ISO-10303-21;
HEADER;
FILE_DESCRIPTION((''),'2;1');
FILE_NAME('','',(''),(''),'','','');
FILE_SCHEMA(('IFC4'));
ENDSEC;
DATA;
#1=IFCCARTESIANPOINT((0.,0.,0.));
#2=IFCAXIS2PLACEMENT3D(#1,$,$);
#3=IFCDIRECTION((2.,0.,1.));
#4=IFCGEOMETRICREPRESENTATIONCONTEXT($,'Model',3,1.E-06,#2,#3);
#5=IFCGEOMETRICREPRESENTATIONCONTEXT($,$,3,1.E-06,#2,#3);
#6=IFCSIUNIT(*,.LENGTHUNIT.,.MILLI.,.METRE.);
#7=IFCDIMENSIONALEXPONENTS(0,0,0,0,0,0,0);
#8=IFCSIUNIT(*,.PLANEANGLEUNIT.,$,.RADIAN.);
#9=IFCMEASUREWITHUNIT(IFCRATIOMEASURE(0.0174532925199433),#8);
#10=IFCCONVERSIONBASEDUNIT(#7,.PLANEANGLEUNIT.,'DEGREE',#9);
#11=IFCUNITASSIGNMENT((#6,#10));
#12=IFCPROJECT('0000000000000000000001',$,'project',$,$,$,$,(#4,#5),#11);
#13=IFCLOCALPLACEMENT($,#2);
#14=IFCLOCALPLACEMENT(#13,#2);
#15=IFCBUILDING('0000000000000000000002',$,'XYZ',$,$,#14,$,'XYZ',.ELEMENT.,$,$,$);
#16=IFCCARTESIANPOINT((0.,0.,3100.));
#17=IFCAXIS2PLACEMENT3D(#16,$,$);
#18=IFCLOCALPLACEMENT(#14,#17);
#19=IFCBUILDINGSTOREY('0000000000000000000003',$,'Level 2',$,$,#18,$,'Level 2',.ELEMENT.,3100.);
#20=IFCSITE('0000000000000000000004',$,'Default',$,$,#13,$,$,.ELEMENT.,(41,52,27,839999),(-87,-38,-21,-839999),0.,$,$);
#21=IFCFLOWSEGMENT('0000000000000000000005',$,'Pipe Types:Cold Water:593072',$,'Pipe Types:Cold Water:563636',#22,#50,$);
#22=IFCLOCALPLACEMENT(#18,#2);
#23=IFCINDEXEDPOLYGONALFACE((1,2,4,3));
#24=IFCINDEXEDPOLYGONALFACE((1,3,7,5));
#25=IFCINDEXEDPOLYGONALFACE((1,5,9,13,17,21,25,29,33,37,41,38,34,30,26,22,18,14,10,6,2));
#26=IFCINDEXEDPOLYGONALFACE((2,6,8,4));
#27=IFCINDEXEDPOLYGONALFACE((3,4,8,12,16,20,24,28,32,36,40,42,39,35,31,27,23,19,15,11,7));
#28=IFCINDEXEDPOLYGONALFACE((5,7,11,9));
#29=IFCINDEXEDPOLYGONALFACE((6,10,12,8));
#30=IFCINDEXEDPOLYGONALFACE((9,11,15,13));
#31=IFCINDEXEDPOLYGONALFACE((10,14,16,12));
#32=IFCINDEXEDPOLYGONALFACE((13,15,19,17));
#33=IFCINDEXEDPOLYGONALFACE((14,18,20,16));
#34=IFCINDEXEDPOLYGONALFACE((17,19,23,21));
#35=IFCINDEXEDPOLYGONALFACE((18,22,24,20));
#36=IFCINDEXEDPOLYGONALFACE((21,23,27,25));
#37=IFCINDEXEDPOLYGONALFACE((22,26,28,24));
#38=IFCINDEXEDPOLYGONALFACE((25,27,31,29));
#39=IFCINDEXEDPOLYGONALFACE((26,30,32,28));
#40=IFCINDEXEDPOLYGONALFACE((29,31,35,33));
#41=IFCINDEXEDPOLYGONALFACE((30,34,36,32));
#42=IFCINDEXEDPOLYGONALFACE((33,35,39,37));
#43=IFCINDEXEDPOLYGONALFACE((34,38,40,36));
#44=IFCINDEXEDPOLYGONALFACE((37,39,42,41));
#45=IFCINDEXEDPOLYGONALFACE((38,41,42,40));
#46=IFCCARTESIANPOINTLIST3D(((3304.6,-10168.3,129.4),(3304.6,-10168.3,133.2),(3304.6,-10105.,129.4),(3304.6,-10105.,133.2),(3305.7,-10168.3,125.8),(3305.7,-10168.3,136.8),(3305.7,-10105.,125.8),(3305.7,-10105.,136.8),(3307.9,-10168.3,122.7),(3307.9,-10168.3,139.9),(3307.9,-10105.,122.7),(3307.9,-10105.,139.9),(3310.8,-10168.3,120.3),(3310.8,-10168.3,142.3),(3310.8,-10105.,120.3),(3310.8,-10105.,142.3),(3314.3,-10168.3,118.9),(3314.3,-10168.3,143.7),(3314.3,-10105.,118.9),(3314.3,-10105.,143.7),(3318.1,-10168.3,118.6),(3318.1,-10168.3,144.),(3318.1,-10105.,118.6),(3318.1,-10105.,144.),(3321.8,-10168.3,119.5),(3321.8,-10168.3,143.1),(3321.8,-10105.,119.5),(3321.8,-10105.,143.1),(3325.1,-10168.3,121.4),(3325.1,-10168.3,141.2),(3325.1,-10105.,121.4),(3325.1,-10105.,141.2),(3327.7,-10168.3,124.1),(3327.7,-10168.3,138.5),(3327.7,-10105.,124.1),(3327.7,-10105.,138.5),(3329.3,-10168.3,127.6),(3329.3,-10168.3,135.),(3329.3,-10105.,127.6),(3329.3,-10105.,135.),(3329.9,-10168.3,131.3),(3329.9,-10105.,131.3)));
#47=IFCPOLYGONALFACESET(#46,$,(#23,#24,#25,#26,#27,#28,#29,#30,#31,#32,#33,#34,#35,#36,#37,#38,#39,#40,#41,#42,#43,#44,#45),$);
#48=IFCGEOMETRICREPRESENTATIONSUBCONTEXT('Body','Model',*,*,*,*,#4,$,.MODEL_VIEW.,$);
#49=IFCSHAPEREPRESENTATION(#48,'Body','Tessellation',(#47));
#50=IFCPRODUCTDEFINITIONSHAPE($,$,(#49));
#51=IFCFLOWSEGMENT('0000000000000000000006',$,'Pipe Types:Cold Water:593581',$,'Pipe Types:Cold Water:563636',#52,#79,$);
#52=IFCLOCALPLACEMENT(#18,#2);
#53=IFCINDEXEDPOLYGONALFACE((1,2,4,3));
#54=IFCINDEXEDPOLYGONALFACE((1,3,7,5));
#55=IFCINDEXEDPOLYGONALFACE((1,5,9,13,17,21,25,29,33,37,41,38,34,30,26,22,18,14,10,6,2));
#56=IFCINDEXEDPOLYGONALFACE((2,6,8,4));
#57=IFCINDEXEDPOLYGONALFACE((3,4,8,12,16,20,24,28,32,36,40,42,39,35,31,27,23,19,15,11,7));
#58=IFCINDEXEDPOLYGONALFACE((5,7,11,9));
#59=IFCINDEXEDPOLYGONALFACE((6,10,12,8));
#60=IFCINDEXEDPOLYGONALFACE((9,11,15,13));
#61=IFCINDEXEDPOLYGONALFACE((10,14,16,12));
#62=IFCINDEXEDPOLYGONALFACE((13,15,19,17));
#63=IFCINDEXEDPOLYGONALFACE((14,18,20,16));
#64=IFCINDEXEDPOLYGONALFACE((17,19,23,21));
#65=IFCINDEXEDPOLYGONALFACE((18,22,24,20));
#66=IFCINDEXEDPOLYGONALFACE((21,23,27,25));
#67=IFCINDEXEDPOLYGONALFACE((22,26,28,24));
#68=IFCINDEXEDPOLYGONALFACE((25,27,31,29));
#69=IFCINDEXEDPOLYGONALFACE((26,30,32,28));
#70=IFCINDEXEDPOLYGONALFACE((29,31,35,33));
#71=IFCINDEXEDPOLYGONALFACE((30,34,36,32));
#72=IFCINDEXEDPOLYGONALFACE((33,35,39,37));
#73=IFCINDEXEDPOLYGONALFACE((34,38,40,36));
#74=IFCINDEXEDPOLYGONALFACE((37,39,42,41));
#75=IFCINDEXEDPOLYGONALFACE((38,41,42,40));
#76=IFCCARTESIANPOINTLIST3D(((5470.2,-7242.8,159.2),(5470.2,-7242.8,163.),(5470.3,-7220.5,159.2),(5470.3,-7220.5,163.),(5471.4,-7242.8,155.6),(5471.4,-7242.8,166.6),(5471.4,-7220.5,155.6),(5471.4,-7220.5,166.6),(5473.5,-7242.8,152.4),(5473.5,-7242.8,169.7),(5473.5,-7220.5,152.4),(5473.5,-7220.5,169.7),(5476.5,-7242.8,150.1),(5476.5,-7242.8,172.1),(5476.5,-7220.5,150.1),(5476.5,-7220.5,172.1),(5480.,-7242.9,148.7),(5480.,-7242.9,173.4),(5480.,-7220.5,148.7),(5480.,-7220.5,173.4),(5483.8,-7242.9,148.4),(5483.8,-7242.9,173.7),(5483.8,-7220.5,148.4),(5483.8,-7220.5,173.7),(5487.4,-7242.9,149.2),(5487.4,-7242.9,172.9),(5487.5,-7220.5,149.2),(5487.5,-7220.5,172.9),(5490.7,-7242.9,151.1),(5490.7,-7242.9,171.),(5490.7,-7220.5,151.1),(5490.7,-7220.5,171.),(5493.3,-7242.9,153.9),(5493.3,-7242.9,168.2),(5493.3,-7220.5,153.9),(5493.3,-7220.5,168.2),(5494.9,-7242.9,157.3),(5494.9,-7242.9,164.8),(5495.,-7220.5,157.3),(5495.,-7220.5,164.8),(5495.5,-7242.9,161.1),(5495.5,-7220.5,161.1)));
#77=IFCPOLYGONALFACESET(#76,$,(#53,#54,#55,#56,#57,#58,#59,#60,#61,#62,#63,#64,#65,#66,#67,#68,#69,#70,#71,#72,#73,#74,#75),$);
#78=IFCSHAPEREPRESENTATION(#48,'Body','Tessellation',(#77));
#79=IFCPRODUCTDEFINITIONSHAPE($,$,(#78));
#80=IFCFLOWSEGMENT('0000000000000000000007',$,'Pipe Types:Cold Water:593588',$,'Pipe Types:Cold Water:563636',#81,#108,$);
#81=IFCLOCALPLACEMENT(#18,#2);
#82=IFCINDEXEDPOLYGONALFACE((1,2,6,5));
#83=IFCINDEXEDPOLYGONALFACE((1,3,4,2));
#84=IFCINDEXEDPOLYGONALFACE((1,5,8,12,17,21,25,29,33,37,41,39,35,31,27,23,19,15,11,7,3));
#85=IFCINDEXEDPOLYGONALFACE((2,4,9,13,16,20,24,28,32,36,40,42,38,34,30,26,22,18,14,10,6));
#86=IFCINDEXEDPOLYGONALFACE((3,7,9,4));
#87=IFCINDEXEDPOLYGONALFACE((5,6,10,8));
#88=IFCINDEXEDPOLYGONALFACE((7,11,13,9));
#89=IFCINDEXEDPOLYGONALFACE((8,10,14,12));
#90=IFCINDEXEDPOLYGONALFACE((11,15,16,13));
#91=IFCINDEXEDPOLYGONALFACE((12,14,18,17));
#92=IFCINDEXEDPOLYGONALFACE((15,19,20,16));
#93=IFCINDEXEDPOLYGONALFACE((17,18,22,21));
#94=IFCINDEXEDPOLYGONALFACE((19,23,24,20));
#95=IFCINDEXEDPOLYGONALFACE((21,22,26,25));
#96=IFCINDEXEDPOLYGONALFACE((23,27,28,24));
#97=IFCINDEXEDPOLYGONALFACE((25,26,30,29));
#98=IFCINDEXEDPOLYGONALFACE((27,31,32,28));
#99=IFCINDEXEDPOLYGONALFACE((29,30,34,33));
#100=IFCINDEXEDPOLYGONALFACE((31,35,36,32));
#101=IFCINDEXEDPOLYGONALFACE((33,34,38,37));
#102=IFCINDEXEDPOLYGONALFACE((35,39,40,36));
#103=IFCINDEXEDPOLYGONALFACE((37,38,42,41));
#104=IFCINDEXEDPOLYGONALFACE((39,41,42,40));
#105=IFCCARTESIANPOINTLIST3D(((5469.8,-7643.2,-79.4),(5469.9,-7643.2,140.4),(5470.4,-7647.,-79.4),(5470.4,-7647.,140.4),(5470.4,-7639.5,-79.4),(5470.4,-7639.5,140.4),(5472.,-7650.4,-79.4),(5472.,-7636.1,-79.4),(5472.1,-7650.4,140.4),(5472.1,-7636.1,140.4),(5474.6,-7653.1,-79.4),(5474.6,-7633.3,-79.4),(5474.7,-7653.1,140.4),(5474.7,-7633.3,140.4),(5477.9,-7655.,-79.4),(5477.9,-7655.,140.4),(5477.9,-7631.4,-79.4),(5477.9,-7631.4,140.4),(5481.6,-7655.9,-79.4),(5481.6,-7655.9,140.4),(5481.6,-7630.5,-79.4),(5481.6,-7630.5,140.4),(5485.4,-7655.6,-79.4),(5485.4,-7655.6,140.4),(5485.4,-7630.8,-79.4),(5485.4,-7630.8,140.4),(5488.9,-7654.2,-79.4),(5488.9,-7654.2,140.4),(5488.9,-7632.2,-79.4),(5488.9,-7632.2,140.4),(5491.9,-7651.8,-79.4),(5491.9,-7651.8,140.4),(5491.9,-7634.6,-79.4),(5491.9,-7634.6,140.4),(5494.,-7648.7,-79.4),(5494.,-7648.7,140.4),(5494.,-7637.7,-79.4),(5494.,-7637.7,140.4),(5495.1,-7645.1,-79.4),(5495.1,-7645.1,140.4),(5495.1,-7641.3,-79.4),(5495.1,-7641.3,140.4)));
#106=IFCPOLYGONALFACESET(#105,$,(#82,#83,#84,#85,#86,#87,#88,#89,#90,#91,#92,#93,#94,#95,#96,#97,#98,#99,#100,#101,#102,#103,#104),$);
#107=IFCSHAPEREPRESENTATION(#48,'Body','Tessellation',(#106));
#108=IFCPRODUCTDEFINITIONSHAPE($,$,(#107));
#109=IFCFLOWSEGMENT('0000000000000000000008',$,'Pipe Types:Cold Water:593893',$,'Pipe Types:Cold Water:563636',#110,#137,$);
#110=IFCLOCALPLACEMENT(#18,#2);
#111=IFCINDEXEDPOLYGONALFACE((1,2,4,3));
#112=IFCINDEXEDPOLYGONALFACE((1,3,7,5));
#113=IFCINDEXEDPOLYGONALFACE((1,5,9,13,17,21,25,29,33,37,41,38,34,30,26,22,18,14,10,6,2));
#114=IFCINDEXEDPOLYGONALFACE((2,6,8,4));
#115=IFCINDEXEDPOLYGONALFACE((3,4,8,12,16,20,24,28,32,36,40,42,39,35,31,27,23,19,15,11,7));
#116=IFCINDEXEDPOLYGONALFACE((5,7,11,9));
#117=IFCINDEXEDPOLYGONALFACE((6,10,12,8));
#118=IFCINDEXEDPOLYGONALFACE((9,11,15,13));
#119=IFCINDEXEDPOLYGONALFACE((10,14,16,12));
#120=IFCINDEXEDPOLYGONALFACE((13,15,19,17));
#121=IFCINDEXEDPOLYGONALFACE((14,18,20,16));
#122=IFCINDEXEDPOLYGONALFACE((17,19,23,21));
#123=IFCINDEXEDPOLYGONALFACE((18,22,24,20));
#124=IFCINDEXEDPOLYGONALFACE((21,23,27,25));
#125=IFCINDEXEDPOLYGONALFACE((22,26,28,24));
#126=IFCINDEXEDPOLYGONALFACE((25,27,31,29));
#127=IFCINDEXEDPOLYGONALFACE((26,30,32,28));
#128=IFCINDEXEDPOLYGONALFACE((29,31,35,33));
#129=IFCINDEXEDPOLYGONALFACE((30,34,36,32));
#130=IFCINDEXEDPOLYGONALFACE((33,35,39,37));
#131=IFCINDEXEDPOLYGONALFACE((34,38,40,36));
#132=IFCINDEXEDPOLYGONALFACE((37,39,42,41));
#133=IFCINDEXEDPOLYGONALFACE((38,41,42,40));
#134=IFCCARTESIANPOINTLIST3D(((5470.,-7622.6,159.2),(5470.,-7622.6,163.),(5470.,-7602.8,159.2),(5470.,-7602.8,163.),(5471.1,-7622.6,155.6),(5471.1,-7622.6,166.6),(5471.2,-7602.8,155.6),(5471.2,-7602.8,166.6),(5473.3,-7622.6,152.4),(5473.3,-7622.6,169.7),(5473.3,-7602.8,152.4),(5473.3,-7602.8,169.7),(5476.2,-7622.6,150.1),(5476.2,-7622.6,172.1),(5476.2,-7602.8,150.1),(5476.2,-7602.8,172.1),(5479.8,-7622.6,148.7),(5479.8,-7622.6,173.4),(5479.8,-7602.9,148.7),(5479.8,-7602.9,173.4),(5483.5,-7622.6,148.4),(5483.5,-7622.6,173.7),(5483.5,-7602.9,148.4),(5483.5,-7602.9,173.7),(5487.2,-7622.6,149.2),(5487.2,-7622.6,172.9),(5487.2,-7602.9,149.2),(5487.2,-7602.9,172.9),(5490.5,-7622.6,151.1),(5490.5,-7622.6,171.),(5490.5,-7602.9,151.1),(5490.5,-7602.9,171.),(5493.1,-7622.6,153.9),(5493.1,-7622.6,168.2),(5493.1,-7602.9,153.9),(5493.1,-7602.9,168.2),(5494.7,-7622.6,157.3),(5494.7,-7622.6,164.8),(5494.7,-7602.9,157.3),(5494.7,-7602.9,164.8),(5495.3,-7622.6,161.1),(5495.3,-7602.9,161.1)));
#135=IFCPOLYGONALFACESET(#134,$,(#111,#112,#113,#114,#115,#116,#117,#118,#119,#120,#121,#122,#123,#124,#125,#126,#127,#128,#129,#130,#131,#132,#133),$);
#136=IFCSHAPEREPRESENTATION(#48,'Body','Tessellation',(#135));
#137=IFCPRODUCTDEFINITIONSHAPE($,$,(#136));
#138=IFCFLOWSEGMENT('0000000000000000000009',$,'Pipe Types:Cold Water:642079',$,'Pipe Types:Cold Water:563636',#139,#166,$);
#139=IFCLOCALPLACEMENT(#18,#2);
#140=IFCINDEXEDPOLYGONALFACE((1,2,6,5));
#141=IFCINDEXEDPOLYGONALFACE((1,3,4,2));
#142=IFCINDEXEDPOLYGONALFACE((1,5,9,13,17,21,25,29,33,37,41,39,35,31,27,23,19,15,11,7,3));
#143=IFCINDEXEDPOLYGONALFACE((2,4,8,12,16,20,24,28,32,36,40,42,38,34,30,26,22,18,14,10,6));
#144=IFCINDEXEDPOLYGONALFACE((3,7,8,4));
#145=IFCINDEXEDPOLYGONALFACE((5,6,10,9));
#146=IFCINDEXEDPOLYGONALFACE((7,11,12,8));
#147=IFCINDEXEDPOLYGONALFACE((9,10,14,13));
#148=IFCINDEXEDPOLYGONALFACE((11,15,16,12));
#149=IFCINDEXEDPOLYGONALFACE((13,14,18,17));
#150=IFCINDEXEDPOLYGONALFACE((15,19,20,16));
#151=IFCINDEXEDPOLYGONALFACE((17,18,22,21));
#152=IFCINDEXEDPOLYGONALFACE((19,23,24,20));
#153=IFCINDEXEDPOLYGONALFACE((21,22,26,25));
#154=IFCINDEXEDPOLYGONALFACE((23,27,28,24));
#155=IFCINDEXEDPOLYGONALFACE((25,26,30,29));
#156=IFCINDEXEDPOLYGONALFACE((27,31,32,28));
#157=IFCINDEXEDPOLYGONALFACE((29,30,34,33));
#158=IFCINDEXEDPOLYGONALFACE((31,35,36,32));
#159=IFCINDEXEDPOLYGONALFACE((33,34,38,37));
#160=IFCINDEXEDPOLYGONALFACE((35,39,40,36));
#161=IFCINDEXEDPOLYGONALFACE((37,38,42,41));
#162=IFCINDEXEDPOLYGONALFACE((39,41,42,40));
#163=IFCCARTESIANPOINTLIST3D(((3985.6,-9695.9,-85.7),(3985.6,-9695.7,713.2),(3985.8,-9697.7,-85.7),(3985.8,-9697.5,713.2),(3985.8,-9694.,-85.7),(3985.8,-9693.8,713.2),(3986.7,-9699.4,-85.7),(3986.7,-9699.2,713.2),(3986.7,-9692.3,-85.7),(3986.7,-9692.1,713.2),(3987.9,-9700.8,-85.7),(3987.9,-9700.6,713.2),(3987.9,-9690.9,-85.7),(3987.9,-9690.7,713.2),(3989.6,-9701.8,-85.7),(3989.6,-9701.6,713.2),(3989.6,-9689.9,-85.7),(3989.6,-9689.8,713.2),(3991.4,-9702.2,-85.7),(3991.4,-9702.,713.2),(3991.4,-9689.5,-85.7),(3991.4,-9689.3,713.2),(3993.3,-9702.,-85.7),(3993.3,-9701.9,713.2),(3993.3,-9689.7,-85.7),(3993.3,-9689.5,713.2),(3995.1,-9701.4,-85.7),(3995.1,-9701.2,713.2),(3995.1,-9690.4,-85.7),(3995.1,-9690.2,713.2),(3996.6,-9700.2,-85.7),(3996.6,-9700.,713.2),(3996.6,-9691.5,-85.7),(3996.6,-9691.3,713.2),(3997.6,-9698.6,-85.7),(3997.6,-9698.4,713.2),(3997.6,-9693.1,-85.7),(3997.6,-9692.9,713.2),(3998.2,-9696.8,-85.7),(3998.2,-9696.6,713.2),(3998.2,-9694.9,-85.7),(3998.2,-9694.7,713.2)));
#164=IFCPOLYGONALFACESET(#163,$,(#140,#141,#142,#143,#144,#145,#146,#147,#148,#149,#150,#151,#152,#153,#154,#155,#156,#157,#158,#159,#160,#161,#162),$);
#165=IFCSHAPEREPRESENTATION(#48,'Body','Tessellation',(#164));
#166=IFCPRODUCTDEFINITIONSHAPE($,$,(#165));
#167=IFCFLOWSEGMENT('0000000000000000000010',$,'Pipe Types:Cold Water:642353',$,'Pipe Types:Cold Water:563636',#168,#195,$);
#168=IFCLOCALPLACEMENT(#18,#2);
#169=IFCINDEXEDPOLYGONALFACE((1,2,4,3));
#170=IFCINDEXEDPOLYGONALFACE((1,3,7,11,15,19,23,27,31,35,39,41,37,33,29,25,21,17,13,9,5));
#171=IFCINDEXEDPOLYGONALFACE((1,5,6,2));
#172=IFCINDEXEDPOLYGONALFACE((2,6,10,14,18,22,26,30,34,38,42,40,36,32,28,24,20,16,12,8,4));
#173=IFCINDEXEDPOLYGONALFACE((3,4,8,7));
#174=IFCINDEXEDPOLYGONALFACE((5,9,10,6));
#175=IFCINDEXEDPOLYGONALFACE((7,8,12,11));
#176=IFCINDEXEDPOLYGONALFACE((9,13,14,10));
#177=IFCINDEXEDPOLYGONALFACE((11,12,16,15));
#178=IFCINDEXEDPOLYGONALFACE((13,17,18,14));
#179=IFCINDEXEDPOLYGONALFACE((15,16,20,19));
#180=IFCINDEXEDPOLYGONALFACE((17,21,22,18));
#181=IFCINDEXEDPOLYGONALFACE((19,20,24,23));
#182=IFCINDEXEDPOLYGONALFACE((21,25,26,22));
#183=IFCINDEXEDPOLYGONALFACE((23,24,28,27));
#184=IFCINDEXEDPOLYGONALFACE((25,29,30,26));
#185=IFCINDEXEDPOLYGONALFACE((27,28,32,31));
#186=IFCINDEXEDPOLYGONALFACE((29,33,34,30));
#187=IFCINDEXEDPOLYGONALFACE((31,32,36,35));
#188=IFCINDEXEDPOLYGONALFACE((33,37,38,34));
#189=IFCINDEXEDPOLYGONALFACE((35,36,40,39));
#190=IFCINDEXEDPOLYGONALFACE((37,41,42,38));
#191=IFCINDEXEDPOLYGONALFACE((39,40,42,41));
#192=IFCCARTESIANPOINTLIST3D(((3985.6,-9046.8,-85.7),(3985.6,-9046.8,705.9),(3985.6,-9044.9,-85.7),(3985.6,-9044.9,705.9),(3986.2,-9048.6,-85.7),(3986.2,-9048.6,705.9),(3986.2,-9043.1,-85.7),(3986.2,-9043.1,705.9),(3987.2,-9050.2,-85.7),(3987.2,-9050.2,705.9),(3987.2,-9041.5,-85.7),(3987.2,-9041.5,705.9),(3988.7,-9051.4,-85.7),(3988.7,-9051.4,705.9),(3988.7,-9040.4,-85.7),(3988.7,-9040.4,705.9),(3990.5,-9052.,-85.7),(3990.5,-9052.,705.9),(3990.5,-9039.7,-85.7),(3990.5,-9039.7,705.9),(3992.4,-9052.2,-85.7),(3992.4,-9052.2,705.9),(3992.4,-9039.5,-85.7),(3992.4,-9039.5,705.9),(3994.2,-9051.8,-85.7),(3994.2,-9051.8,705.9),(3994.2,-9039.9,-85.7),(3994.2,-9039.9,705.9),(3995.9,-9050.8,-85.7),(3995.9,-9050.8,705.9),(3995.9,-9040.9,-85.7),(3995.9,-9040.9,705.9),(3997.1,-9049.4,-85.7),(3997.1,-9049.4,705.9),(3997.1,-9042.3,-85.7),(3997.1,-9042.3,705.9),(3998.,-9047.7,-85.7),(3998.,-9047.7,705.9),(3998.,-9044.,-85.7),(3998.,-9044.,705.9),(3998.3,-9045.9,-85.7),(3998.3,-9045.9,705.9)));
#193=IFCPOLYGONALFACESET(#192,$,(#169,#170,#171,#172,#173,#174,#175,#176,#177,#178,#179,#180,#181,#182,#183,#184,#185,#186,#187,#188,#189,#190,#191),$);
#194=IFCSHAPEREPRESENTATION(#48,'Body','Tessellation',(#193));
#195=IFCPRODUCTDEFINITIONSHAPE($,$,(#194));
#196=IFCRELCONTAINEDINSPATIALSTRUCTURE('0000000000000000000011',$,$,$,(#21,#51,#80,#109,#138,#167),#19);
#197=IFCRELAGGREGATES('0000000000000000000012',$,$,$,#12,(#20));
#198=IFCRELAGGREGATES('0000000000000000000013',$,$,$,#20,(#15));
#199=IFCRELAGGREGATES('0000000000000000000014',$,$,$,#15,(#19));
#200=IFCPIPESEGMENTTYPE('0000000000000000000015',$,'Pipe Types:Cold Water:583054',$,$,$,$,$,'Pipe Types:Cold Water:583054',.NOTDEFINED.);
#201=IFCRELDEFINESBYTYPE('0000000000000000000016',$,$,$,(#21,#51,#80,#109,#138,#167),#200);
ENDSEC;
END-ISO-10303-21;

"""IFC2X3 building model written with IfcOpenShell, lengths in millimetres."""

from ifc_helpers import new_model, entity, si_unit, converted_unit, direction, frame, frame_2d, origin, origin_2d_with_axis, place, context, subcontext, project, spatial, circle, extrude, type_object, element, save


model = new_model("IFC2X3")

# Units and contexts
model_context = context("Model", 3, precision=1e-06, world=origin(), true_north=direction((2.0, 0.0, 1.0)))
context_of_model = context(None, 3, precision=1e-06, world=origin(), true_north=direction((2.0, 0.0, 1.0)))
body_context = subcontext(model_context, "Body", "Model", "MODEL_VIEW")
ifc_project = project(units=[si_unit("LENGTHUNIT", "METRE", prefix="MILLI"), converted_unit("PLANEANGLEUNIT", "DEGREE", entity("IfcRatioMeasure", 0.0174532925199433), si_unit("PLANEANGLEUNIT", "RADIAN"), dimensions=[0, 0, 0, 0, 0, 0, 0])], contexts=[model_context, context_of_model])

# Site, building, storey
site_placement = place(None, origin())
site = spatial("IfcSite", under=ifc_project, at=site_placement, Name="Default", CompositionType="ELEMENT", RefLatitude=(41, 52, 27, 839999), RefLongitude=(-87, -38, -21, -839999), RefElevation=0.0)
building_placement = place(site_placement, origin())
building = spatial("IfcBuilding", under=site, at=building_placement, Name="XYZ", LongName="XYZ", CompositionType="ELEMENT")
storey_placement = place(building_placement, frame((0.0, 0.0, 3100.0)))
storey = spatial("IfcBuildingStorey", under=building, at=storey_placement, Name="Level 2", LongName="Level 2", CompositionType="ELEMENT", Elevation=3100.0)

# Flow segments
pipe_segment_type_1 = type_object("IfcPipeSegmentType", Name="Pipe Types:Cold Water:583054", ElementType="Pipe Types:Cold Water:583054", PredefinedType="NOTDEFINED")
flow_segment_1_placement = place(storey_placement, origin())
element("IfcFlowSegment", 1, at=flow_segment_1_placement, inside=storey, type_object=pipe_segment_type_1, Name="Pipe Types:Cold Water:593072", ObjectType="Pipe Types:Cold Water:563636", context=body_context, shape_type="SweptSolid", body=[
    extrude(circle(Radius=12.7, at=origin_2d_with_axis()), frame((3317.2, -10168.3, 131.3), z_axis=(0.0, 1.0, 0.0), x_axis=(1.0, 0.0, 0.0)), (0.0, 0.0, 1.0), 63.3),
])
flow_segment_2_placement = place(storey_placement, origin())
element("IfcFlowSegment", 2, at=flow_segment_2_placement, inside=storey, type_object=pipe_segment_type_1, Name="Pipe Types:Cold Water:593581", ObjectType="Pipe Types:Cold Water:563636", context=body_context, shape_type="SweptSolid", body=[
    extrude(circle(Radius=12.7, at=frame_2d((0.0, 0.0), x_axis=(1.0, 0.0))), frame((5482.8, -7242.9, 161.1), z_axis=(0.000669, 1.0, 0.0), x_axis=(1.0, -0.000669, 0.0)), (0.0, 0.0, 1.0), 22.4),
])
flow_segment_3_placement = place(storey_placement, origin())
element("IfcFlowSegment", 3, at=flow_segment_3_placement, inside=storey, type_object=pipe_segment_type_1, Name="Pipe Types:Cold Water:593588", ObjectType="Pipe Types:Cold Water:563636", context=body_context, shape_type="SweptSolid", body=[
    extrude(circle(Radius=12.7, at=origin_2d_with_axis()), frame((5482.6, -7643.2, 140.4), z_axis=(-0.000127, 0.0, -1.0), x_axis=(-1.0, 0.0, 0.000127)), (0.0, 0.0, 1.0), 219.8),
])
flow_segment_4_placement = place(storey_placement, origin())
element("IfcFlowSegment", 4, at=flow_segment_4_placement, inside=storey, type_object=pipe_segment_type_1, Name="Pipe Types:Cold Water:593893", ObjectType="Pipe Types:Cold Water:563636", context=body_context, shape_type="SweptSolid", body=[
    extrude(circle(Radius=12.7, at=frame_2d((0.0, 0.0), x_axis=(1.0, 0.0))), frame((5482.6, -7622.6, 161.1), z_axis=(0.000618, 1.0, 0.0), x_axis=(1.0, -0.000618, 0.0)), (0.0, 0.0, 1.0), 19.7),
])
flow_segment_5_placement = place(storey_placement, origin())
element("IfcFlowSegment", 5, at=flow_segment_5_placement, inside=storey, type_object=pipe_segment_type_1, Name="Pipe Types:Cold Water:642079", ObjectType="Pipe Types:Cold Water:563636", context=body_context, shape_type="SweptSolid", body=[
    extrude(circle(Radius=6.3, at=origin_2d_with_axis()), frame((3991.9, -9695.9, -85.7), z_axis=(0.0, 0.000228, 1.0), x_axis=(-1.0, 0.0, 0.0)), (0.0, 0.0, 1.0), 798.9),
])
flow_segment_6_placement = place(storey_placement, origin())
element("IfcFlowSegment", 6, at=flow_segment_6_placement, inside=storey, type_object=pipe_segment_type_1, Name="Pipe Types:Cold Water:642353", ObjectType="Pipe Types:Cold Water:563636", context=body_context, shape_type="SweptSolid", body=[
    extrude(circle(Radius=6.3, at=origin_2d_with_axis()), frame((3991.9, -9045.9, -85.7)), (0.0, 0.0, 1.0), 791.6),
])

save(model, "model.ifc")
